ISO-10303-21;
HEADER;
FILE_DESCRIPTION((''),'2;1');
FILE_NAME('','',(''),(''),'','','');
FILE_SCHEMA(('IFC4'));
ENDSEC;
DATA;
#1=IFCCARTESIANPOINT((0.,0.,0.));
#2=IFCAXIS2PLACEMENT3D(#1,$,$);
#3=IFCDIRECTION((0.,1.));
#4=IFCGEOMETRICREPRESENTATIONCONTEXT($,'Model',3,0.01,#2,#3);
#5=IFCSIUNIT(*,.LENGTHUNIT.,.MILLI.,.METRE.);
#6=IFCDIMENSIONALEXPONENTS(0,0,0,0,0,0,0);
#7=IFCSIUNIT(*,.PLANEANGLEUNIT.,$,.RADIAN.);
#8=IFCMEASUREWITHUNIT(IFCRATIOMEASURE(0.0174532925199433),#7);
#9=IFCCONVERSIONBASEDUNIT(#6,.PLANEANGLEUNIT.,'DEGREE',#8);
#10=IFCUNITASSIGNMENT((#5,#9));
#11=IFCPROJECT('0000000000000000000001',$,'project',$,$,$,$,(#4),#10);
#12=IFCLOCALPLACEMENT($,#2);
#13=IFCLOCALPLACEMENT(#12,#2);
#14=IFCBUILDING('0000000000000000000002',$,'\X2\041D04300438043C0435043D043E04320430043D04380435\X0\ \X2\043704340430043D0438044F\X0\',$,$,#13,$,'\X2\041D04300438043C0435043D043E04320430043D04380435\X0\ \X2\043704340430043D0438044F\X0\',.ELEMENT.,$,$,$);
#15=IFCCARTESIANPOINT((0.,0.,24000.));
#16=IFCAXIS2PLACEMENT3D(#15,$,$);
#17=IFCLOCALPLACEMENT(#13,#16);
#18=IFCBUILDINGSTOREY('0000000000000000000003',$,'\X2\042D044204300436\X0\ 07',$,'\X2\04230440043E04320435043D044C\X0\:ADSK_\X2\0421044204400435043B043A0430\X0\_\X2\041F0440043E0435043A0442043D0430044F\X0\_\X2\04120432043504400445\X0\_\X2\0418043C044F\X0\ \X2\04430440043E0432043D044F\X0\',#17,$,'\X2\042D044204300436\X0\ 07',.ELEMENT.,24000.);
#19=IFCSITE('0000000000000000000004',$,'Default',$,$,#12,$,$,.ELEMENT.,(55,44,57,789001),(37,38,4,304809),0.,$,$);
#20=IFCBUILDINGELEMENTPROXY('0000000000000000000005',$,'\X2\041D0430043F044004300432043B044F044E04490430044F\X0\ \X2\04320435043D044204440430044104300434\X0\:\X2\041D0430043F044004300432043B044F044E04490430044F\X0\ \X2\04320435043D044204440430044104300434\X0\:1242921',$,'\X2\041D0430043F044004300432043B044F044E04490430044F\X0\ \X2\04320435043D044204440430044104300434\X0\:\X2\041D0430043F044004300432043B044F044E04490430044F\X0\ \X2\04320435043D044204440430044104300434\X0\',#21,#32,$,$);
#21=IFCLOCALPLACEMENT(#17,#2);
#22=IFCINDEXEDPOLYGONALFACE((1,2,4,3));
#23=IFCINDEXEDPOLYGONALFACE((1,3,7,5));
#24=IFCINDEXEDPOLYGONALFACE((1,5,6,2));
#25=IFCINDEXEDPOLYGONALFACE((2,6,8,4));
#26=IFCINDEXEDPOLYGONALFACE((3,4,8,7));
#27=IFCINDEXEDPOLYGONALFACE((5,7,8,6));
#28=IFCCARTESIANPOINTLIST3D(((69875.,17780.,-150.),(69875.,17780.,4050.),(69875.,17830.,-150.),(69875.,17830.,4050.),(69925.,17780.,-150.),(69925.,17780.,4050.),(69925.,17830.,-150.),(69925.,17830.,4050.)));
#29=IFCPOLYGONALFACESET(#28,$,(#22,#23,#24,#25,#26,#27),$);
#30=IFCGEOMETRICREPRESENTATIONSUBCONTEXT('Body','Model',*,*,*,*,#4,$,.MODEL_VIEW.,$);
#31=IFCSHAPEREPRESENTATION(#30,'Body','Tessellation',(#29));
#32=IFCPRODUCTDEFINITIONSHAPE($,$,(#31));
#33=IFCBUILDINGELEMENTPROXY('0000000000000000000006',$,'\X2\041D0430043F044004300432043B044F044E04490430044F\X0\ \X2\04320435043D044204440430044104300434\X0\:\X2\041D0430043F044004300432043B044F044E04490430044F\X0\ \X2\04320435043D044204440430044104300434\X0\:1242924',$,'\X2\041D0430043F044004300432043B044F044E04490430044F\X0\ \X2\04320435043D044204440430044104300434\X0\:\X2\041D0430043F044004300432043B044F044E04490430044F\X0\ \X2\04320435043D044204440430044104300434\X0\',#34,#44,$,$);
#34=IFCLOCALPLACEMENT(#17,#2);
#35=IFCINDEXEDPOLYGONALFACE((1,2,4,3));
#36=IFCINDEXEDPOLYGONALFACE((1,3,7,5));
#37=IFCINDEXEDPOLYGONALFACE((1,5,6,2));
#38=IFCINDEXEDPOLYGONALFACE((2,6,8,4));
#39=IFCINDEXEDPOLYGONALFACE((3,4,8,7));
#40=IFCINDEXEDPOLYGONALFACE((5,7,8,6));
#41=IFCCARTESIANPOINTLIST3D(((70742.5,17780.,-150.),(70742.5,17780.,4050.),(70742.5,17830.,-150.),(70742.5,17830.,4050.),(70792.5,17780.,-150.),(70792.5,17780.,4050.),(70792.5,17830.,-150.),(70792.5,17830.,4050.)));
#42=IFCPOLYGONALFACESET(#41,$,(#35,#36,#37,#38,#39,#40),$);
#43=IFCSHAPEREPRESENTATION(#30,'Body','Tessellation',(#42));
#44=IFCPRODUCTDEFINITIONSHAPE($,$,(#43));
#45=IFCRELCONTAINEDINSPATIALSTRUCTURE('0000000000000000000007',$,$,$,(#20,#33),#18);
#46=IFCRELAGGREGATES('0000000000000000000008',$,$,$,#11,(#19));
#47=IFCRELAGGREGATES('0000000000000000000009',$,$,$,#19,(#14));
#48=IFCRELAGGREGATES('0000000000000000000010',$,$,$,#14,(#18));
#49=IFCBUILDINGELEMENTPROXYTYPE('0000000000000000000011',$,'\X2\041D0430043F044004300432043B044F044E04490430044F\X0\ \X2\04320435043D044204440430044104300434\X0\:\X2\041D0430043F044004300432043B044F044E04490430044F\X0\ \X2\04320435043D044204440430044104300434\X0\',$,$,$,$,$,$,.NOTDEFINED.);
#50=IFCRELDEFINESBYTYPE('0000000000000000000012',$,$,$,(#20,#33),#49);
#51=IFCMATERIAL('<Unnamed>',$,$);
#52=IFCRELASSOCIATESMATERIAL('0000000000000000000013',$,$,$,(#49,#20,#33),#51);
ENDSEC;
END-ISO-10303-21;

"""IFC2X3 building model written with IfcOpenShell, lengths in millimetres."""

from ifc_helpers import new_model, entity, si_unit, converted_unit, direction, frame, origin, origin_2d_with_axis, place, context, subcontext, project, spatial, rectangle, extrude, source, transform, mapped, material, type_object, type_shapes, element, save


model = new_model("IFC2X3")

# Units and contexts
model_context = context("Model", 3, precision=0.01, world=origin(), true_north=direction((0.0, 1.0)))
body_context = subcontext(model_context, "Body", "Model", "MODEL_VIEW")
ifc_project = project(units=[si_unit("LENGTHUNIT", "METRE", prefix="MILLI"), converted_unit("PLANEANGLEUNIT", "DEGREE", entity("IfcRatioMeasure", 0.0174532925199433), si_unit("PLANEANGLEUNIT", "RADIAN"), dimensions=[0, 0, 0, 0, 0, 0, 0])], contexts=[model_context])

# Site, building, storey
site_placement = place(None, origin())
site = spatial("IfcSite", under=ifc_project, at=site_placement, Name="Default", CompositionType="ELEMENT", RefLatitude=(55, 44, 57, 789001), RefLongitude=(37, 38, 4, 304809), RefElevation=0.0)
building_placement = place(site_placement, origin())
building = spatial("IfcBuilding", under=site, at=building_placement, Name="Наименование здания", LongName="Наименование здания", CompositionType="ELEMENT")
storey_placement = place(building_placement, frame((0.0, 0.0, 24000.0)))
storey = spatial("IfcBuildingStorey", under=building, at=storey_placement, Name="Этаж 07", ObjectType="Уровень:ADSK_Стрелка_Проектная_Вверх_Имя уровня", LongName="Этаж 07", CompositionType="ELEMENT", Elevation=24000.0)

# Building element proxies
ifc_material_1 = material(Name="<Unnamed>")
building_element_proxy_type_1 = type_object("IfcBuildingElementProxyType", Name="Направляющая вентфасад:Направляющая вентфасад", PredefinedType="NOTDEFINED", material=ifc_material_1)
shared_shape_1 = source(origin(), body_context, "Body", "SweptSolid", [
    extrude(rectangle(XDim=50.0, YDim=50.0, at=origin_2d_with_axis()), frame((25.0, -25.0, 0.0), z_axis=(0.0, 0.0, 1.0), x_axis=(-1.0, 0.0, 0.0)), (0.0, 0.0, 1.0), 4200.0),
])
type_shapes(building_element_proxy_type_1, [shared_shape_1])
for number, where, z_axis, x_axis, name in (
    (1, (69925.0, 17780.0, -150.0), (0.0, 0.0, 1.0), (-1.0, 0.0, 0.0), "Направляющая вентфасад:Направляющая вентфасад:1242921"),
    (2, (70792.5, 17780.0, -150.0), (0.0, 0.0, 1.0), (-1.0, 0.0, 0.0), "Направляющая вентфасад:Направляющая вентфасад:1242924"),
):
    element("IfcBuildingElementProxy", number, at=place(storey_placement, frame(where, z_axis=z_axis, x_axis=x_axis)), inside=storey, type_object=building_element_proxy_type_1, material=ifc_material_1, Name=name, ObjectType="Направляющая вентфасад:Направляющая вентфасад", context=body_context, shape_type="MappedRepresentation", body=[
        mapped(shared_shape_1, transform((0.0, 0.0, 0.0), scale=1.0)),
    ])

save(model, "model.ifc")
